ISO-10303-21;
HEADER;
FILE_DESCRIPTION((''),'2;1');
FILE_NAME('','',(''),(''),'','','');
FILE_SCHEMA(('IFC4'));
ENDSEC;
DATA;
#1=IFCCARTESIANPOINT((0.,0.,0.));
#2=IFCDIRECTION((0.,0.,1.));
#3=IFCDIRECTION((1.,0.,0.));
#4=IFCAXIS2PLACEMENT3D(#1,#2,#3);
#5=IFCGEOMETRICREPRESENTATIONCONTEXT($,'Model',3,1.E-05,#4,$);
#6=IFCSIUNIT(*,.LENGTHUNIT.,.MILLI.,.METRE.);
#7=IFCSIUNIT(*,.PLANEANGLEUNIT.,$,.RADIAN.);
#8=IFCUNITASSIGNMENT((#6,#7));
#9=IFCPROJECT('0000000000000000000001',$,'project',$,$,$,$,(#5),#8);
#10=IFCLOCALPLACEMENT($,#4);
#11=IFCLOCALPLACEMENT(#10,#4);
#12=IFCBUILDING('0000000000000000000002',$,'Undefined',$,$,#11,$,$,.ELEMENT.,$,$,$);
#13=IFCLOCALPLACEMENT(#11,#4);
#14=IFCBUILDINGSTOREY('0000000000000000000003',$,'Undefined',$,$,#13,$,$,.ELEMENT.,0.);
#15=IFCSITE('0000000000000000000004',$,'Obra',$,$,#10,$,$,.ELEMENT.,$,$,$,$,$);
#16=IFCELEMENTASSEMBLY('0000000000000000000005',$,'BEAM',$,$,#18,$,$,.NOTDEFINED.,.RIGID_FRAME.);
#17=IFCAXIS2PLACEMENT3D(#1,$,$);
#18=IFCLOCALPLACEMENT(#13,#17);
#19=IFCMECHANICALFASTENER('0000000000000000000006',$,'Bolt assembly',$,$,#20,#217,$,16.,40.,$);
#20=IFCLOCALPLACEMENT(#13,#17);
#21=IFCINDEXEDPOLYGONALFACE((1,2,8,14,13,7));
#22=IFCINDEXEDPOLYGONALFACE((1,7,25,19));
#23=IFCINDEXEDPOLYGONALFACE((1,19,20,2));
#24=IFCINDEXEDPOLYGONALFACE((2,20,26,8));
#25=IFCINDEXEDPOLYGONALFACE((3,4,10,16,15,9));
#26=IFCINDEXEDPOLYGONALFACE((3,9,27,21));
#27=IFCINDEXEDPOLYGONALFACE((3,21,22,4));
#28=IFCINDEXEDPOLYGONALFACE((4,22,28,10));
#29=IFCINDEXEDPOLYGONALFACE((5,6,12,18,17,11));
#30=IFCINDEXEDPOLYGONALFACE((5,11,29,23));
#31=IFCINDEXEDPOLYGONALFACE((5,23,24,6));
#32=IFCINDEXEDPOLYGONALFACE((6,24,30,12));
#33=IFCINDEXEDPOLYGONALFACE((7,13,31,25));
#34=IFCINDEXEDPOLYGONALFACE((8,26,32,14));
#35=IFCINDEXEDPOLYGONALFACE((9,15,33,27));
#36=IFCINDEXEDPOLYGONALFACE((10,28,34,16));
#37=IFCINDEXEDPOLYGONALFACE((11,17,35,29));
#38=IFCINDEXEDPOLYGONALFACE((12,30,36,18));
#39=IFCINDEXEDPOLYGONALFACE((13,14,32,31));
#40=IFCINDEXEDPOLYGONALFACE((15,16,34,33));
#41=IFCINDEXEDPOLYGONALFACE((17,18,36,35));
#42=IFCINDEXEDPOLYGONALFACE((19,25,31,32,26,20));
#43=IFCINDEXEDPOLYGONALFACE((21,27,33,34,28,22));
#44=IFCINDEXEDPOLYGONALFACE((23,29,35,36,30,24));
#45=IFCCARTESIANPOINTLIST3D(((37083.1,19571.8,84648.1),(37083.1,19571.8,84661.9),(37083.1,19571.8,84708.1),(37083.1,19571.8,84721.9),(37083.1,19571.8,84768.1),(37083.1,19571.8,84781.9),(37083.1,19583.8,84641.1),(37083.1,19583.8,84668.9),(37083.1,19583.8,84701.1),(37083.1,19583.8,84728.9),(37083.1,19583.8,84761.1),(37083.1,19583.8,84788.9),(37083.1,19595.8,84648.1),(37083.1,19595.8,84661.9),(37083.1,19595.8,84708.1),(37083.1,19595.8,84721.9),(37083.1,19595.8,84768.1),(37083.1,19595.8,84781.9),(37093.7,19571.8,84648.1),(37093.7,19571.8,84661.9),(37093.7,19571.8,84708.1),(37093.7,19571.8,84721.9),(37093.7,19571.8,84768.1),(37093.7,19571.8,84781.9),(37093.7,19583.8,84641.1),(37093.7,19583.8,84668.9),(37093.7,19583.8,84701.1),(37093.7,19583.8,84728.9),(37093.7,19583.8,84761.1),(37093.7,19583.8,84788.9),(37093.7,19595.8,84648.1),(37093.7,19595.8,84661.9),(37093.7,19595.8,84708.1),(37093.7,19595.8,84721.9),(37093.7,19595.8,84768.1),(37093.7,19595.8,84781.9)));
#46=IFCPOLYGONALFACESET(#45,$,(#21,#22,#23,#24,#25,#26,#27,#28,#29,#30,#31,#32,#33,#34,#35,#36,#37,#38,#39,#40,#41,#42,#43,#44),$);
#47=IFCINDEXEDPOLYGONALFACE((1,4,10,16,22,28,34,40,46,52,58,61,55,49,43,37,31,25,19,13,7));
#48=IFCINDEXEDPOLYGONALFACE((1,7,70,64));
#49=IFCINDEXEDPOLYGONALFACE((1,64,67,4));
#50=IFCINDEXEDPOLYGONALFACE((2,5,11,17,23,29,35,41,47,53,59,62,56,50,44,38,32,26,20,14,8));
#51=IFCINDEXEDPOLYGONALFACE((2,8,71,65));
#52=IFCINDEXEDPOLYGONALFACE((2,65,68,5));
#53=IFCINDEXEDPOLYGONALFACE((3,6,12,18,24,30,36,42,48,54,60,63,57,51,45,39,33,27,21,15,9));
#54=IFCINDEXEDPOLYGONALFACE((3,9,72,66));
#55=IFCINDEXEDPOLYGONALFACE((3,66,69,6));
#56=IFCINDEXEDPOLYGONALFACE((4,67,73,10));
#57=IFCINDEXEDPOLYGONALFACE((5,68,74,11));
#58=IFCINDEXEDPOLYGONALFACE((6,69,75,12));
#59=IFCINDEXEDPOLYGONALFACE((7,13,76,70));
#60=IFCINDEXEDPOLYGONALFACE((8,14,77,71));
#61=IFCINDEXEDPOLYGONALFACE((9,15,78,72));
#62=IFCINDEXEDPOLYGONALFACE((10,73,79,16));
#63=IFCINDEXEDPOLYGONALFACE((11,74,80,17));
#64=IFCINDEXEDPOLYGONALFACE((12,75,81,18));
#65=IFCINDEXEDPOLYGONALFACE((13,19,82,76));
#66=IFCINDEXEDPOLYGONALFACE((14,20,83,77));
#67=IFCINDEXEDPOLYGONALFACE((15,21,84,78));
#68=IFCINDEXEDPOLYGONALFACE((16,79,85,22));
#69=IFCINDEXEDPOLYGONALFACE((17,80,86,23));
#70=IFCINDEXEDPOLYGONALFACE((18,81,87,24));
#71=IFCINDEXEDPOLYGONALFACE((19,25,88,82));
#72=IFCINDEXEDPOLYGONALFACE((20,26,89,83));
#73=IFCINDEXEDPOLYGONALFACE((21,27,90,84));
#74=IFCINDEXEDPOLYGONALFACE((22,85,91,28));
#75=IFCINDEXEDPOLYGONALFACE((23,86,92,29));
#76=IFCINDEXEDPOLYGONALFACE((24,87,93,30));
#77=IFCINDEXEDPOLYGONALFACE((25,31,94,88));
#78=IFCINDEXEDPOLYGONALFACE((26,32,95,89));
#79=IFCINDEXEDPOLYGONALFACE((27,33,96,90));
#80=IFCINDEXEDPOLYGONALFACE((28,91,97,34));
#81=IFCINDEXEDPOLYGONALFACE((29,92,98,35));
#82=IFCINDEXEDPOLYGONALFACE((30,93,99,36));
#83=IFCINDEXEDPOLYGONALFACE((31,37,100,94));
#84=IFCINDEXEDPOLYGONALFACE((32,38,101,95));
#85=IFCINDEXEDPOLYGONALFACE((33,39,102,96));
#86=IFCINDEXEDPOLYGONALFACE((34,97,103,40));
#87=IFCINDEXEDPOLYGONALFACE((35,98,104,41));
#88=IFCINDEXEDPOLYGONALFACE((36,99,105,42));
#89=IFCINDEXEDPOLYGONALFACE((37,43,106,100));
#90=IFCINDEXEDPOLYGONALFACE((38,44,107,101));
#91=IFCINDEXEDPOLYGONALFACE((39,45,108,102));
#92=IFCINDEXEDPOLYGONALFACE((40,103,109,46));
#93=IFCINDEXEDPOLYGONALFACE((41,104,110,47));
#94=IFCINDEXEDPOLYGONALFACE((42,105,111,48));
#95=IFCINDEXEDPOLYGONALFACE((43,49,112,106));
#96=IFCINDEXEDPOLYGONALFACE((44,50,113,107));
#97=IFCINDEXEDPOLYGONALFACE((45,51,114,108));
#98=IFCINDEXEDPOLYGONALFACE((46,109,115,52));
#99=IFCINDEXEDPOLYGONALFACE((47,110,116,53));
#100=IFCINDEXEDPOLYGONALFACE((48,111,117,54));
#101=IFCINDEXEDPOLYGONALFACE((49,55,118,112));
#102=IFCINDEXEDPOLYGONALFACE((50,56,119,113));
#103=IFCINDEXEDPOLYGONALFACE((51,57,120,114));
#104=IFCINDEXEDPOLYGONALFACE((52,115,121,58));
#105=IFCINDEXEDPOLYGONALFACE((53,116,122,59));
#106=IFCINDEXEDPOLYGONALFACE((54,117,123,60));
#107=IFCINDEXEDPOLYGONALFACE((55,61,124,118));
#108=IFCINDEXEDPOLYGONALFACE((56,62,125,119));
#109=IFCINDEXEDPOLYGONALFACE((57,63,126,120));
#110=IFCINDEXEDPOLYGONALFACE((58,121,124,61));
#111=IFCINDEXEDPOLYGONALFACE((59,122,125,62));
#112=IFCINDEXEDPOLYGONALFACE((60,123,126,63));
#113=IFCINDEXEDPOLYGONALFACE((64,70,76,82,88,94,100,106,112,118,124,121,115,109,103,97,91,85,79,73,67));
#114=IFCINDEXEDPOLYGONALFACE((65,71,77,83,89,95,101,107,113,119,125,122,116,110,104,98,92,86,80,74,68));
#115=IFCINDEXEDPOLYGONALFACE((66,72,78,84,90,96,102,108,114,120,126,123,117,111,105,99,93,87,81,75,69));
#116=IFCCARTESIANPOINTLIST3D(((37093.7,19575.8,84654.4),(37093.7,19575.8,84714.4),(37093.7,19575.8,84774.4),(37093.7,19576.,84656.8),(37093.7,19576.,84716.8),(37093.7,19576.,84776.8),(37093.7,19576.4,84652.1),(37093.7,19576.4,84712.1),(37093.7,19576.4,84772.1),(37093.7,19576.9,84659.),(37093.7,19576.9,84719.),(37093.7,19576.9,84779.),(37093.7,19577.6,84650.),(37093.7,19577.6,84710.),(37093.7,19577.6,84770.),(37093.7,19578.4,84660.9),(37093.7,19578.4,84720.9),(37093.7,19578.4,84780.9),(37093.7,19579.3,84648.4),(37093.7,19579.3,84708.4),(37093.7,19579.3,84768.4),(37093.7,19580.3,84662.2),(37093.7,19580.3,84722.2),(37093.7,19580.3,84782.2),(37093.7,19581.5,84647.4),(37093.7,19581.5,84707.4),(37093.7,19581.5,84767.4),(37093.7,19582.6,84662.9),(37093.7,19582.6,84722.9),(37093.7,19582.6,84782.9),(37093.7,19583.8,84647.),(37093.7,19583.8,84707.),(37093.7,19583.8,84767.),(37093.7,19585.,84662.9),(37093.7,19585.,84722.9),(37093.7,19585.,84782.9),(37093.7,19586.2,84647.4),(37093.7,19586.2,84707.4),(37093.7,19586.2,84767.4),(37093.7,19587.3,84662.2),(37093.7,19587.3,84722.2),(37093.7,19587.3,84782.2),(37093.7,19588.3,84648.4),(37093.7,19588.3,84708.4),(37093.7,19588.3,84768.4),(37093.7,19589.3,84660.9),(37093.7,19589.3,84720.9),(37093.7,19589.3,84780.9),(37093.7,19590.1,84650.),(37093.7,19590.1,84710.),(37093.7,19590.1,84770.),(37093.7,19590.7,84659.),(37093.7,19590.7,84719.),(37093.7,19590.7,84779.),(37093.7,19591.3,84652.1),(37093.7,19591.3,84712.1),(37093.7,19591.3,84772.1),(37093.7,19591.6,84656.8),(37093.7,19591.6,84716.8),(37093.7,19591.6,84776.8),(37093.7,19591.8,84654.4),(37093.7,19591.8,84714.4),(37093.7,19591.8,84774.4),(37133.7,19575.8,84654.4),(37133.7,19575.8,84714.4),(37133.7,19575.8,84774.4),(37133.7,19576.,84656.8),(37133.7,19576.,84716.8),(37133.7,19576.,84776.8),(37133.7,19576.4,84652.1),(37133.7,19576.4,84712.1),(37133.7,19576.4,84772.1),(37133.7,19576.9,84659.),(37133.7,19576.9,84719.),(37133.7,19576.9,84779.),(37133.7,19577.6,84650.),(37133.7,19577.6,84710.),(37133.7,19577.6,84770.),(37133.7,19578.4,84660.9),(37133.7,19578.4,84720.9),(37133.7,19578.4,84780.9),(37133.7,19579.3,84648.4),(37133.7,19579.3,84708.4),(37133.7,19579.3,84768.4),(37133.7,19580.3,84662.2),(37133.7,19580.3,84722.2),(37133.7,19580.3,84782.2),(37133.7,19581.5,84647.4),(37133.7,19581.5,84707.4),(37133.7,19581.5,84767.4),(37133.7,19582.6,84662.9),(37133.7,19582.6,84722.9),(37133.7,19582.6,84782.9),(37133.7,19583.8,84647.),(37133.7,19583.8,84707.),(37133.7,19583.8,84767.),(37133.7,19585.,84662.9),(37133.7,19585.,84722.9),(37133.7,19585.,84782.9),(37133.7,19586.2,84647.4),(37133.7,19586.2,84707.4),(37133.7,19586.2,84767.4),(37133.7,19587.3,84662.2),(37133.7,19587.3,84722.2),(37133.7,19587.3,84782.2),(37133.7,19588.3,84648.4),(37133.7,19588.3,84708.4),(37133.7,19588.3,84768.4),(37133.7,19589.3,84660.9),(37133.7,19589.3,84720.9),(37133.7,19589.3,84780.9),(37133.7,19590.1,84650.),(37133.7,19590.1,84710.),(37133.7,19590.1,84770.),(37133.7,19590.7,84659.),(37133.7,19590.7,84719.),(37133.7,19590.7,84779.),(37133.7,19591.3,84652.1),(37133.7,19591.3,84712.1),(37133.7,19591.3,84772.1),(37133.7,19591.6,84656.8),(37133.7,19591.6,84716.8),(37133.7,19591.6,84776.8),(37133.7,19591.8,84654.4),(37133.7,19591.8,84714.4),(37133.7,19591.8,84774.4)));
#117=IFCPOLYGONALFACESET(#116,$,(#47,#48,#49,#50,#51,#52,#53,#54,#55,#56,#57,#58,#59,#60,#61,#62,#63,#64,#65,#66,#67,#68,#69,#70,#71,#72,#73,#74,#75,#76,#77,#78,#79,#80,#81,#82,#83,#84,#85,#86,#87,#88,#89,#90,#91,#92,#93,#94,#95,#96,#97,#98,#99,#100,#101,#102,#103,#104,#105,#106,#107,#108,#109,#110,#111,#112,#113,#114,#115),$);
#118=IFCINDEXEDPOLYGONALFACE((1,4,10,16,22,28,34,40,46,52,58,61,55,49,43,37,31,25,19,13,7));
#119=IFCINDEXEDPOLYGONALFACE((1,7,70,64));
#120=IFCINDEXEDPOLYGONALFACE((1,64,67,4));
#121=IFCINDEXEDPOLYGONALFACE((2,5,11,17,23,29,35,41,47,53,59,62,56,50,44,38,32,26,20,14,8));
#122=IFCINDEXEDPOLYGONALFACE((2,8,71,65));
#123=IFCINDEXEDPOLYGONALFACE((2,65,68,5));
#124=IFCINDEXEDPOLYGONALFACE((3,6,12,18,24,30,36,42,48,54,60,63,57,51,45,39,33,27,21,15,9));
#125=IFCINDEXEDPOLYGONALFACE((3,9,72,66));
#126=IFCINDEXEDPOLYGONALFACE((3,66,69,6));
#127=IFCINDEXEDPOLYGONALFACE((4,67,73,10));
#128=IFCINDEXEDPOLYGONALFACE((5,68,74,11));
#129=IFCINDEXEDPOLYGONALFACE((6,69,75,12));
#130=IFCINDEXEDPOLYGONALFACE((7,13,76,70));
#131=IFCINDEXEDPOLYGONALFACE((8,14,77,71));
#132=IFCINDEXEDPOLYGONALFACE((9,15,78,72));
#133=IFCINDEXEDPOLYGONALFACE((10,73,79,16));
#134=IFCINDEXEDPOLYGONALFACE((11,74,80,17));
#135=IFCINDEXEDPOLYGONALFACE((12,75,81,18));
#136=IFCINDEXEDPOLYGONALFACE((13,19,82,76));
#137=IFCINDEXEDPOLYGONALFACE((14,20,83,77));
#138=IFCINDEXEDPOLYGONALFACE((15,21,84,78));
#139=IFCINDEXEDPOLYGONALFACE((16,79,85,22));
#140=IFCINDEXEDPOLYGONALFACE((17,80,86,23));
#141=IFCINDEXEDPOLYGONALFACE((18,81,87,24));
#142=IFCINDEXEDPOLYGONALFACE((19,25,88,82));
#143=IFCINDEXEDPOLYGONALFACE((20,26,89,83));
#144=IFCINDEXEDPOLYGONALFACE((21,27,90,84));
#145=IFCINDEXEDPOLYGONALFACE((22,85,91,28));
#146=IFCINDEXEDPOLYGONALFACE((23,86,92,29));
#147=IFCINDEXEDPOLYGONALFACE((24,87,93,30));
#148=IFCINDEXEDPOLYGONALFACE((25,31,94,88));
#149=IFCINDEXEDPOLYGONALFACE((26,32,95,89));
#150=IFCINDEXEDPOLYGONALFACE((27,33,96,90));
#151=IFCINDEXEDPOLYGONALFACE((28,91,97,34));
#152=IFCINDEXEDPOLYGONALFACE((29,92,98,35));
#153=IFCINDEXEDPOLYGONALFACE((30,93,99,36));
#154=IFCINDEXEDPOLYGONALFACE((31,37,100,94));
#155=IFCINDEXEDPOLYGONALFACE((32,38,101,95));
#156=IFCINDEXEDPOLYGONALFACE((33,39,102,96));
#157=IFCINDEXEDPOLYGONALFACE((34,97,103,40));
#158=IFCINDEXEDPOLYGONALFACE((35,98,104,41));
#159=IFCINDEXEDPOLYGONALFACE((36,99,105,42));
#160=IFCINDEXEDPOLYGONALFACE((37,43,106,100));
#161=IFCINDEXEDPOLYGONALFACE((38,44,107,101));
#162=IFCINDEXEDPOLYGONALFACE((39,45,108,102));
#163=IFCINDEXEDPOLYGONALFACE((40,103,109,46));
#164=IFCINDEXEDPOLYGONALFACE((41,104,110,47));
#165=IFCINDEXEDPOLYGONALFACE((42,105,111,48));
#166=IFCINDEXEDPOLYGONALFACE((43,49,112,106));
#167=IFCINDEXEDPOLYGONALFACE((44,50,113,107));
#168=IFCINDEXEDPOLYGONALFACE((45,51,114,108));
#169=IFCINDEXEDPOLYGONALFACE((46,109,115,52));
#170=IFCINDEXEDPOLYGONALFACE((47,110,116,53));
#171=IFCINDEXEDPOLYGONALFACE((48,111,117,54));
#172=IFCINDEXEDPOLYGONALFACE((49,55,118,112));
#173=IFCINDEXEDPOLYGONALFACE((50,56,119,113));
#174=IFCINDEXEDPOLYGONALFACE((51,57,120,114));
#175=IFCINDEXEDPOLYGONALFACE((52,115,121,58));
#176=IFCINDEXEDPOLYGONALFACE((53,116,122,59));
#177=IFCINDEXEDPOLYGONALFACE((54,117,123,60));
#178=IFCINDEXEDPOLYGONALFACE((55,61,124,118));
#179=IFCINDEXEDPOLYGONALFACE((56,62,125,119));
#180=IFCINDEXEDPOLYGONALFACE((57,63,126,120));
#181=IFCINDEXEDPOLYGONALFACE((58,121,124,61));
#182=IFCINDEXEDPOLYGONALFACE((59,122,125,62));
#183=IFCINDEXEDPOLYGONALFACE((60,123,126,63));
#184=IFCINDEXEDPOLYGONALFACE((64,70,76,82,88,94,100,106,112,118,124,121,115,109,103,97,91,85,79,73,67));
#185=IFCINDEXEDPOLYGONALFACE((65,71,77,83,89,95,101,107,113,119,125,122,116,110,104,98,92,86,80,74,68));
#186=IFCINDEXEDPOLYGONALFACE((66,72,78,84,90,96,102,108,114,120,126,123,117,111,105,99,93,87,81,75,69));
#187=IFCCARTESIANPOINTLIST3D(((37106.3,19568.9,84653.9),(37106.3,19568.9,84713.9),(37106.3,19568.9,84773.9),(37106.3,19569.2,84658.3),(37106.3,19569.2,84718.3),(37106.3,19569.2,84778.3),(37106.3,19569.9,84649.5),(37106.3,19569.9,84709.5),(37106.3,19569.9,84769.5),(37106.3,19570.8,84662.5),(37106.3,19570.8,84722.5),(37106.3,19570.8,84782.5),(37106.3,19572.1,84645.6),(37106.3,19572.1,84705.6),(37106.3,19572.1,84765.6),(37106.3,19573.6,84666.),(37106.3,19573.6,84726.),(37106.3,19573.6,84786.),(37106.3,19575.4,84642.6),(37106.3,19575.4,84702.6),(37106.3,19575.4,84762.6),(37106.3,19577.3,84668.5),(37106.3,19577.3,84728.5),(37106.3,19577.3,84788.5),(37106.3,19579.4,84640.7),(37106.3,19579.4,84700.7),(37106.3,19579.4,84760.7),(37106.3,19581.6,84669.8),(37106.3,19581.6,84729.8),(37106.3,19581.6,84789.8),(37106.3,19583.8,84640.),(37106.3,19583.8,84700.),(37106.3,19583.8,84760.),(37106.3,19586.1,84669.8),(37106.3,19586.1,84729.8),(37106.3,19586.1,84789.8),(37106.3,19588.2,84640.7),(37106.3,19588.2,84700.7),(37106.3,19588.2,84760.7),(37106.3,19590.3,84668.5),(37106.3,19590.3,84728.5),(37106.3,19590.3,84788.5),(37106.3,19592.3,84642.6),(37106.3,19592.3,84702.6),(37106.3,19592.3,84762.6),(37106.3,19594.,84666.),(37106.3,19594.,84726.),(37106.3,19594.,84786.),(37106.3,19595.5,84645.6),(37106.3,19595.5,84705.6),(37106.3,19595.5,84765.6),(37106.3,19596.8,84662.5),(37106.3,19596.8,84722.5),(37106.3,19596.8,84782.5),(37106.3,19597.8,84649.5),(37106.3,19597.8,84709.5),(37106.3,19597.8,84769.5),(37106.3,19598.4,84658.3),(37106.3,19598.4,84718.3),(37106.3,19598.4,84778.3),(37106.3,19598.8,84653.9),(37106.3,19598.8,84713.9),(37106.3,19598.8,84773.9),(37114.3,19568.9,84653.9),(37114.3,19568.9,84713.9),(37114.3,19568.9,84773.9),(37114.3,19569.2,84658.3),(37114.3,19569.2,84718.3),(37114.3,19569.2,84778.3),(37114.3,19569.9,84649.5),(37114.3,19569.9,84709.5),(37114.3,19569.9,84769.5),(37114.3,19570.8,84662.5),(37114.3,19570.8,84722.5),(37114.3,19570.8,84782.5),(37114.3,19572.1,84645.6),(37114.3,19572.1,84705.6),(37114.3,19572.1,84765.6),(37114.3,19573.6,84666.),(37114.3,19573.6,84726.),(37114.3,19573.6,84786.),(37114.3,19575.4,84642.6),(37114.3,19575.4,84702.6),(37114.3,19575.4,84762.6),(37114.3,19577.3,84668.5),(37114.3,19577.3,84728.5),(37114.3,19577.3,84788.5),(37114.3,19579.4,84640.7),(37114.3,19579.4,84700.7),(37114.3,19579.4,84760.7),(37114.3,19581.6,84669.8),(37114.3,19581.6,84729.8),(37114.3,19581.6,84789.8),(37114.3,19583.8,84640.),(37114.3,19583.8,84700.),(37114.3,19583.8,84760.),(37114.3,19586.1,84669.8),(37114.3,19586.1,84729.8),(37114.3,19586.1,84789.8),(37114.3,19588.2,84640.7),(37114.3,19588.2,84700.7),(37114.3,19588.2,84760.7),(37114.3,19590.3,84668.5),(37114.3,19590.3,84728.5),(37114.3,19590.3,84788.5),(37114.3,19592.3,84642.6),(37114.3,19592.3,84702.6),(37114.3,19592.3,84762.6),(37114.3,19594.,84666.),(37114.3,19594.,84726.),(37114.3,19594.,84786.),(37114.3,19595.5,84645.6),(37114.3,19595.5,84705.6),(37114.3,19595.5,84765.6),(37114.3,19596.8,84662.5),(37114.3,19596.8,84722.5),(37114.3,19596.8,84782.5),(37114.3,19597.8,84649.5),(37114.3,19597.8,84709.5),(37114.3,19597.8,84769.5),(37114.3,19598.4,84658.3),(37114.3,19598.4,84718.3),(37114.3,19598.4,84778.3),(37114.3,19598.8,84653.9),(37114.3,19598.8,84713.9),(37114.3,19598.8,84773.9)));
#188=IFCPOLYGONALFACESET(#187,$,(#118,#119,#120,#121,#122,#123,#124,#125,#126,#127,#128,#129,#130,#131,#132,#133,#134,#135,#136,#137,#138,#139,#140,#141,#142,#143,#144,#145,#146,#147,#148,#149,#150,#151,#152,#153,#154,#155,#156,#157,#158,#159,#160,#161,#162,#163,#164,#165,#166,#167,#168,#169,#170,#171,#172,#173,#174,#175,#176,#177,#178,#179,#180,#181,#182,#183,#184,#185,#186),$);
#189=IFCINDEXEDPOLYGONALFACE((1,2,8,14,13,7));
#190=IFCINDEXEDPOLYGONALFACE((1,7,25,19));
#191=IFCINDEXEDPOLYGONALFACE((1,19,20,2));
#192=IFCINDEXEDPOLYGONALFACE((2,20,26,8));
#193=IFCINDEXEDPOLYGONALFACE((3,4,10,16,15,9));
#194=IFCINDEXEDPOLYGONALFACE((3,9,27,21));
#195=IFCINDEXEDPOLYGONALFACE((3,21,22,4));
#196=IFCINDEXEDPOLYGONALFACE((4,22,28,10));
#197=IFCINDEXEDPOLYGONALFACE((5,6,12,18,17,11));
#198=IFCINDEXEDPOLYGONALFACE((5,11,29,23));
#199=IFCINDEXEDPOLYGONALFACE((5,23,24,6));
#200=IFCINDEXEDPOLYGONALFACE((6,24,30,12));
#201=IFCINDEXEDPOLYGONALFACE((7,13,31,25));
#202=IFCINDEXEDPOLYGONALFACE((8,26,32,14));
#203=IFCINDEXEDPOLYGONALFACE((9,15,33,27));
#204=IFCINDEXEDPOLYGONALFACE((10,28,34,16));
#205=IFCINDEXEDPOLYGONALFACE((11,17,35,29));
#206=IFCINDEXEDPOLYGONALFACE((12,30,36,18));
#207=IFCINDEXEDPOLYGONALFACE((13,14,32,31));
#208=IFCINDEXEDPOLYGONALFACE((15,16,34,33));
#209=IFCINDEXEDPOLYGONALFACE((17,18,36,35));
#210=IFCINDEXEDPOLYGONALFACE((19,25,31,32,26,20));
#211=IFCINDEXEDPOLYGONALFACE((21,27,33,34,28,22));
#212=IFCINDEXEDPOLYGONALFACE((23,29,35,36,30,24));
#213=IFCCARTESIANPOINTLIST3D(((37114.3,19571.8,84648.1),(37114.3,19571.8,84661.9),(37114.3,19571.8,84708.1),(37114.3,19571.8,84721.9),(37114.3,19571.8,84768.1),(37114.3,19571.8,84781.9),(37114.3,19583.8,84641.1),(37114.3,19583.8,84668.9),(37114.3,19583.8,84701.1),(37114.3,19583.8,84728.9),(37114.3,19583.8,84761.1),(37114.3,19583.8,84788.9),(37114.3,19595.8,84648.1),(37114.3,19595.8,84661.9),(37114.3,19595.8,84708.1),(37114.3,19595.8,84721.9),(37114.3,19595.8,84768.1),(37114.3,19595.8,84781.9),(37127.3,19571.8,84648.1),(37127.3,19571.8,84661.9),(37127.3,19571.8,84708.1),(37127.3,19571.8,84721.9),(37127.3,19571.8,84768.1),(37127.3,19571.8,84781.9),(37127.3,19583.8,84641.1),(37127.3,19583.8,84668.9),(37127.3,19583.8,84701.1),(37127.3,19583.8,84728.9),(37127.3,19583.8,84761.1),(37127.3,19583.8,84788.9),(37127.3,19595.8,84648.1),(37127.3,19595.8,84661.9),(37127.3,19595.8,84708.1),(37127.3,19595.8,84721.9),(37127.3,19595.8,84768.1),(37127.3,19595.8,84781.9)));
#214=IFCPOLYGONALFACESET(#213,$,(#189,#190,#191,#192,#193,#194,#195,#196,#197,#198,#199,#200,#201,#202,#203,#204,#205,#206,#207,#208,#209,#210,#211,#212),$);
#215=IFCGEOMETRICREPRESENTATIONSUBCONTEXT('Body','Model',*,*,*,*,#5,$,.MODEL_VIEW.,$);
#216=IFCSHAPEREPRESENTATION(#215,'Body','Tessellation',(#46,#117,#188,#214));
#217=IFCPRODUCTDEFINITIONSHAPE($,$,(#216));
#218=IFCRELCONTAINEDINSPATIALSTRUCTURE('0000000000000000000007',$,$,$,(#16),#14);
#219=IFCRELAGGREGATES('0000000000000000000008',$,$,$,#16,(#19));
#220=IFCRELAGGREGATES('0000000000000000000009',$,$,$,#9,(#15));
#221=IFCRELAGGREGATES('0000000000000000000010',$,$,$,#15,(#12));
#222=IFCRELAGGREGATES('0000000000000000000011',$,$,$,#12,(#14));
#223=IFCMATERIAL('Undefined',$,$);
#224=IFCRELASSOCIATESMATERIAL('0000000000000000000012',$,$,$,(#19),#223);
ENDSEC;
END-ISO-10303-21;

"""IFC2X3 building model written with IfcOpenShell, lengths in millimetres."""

from ifc_helpers import new_model, si_unit, frame, origin_with_axes, origin_2d_with_axis, place, context, subcontext, project, spatial, polyline, circle, outline, extrude, source, transform, mapped, material, element, aggregate, save


model = new_model("IFC2X3")

# Units and contexts
model_context = context("Model", 3, precision=1e-05, world=origin_with_axes())
body_context = subcontext(model_context, "Body", "Model", "MODEL_VIEW")
ifc_project = project(units=[si_unit("LENGTHUNIT", "METRE", prefix="MILLI"), si_unit("PLANEANGLEUNIT", "RADIAN")], contexts=[model_context])

# Site, building, storey
site_placement = place(None, origin_with_axes())
site = spatial("IfcSite", under=ifc_project, at=site_placement, Name="Obra", CompositionType="ELEMENT")
building_placement = place(site_placement, origin_with_axes())
building = spatial("IfcBuilding", under=site, at=building_placement, Name="Undefined", CompositionType="ELEMENT")
storey_placement = place(building_placement, origin_with_axes())
storey = spatial("IfcBuildingStorey", under=building, at=storey_placement, Name="Undefined", CompositionType="ELEMENT", Elevation=0.0)

# Shared definitions
ifc_material_1 = material(Name="Undefined")
shared_shape_1 = source(origin_with_axes(), body_context, "Body", "SweptSolid", [
    extrude(outline(polyline([(13.9, 0.0), (6.9, 12.0), (-6.9, 12.0), (-13.9, 0.0), (-6.9, -12.0), (6.9, -12.0), (13.9, 0.0)])), frame((0.0, -19.9, 0.0), z_axis=(0.0, 1.0, 0.0), x_axis=(1.0, 0.0, 0.0)), (0.0, 0.0, 1.0), 10.6),
    extrude(circle(Radius=8.0, at=origin_2d_with_axis()), frame((0.0, -9.3, 0.0), z_axis=(0.0, 1.0, 0.0), x_axis=(1.0, 0.0, 0.0)), (0.0, 0.0, 1.0), 40.0),
    extrude(circle(Radius=15.0, at=origin_2d_with_axis()), frame((0.0, 3.3, 0.0), z_axis=(0.0, 1.0, 0.0), x_axis=(1.0, 0.0, 0.0)), (0.0, 0.0, 1.0), 8.0),
    extrude(outline(polyline([(13.9, 0.0), (6.9, 12.0), (-6.9, 12.0), (-13.9, 0.0), (-6.9, -12.0), (6.9, -12.0), (13.9, 0.0)])), frame((0.0, 11.3, 0.0), z_axis=(0.0, 1.0, 0.0), x_axis=(1.0, 0.0, 0.0)), (0.0, 0.0, 1.0), 13.0),
])

# Element assembly, mechanical fastener
assembly_1_placement = place(storey_placement, origin_with_axes())
assembly_1 = element("IfcElementAssembly", 1, at=assembly_1_placement, inside=storey, Name="BEAM", AssemblyPlace="NOTDEFINED", PredefinedType="RIGID_FRAME")
mechanical_fastener_1_placement = place(assembly_1_placement, frame((37103.0, 19633.8, 84850.0), z_axis=(0.0, -1.0, 0.0), x_axis=(0.0, 0.0, -1.0)))
mechanical_fastener_1 = element("IfcMechanicalFastener", 2, at=mechanical_fastener_1_placement, material=ifc_material_1, Name="Bolt assembly", NominalDiameter=16.0, NominalLength=40.0, context=body_context, shape_type="MappedRepresentation", body=[
    mapped(shared_shape_1, transform((75.0, 0.0, 50.0))),
    mapped(shared_shape_1, transform((135.0, 0.0, 50.0))),
    mapped(shared_shape_1, transform((195.0, 0.0, 50.0))),
])
aggregate(assembly_1, [mechanical_fastener_1])

save(model, "model.ifc")
